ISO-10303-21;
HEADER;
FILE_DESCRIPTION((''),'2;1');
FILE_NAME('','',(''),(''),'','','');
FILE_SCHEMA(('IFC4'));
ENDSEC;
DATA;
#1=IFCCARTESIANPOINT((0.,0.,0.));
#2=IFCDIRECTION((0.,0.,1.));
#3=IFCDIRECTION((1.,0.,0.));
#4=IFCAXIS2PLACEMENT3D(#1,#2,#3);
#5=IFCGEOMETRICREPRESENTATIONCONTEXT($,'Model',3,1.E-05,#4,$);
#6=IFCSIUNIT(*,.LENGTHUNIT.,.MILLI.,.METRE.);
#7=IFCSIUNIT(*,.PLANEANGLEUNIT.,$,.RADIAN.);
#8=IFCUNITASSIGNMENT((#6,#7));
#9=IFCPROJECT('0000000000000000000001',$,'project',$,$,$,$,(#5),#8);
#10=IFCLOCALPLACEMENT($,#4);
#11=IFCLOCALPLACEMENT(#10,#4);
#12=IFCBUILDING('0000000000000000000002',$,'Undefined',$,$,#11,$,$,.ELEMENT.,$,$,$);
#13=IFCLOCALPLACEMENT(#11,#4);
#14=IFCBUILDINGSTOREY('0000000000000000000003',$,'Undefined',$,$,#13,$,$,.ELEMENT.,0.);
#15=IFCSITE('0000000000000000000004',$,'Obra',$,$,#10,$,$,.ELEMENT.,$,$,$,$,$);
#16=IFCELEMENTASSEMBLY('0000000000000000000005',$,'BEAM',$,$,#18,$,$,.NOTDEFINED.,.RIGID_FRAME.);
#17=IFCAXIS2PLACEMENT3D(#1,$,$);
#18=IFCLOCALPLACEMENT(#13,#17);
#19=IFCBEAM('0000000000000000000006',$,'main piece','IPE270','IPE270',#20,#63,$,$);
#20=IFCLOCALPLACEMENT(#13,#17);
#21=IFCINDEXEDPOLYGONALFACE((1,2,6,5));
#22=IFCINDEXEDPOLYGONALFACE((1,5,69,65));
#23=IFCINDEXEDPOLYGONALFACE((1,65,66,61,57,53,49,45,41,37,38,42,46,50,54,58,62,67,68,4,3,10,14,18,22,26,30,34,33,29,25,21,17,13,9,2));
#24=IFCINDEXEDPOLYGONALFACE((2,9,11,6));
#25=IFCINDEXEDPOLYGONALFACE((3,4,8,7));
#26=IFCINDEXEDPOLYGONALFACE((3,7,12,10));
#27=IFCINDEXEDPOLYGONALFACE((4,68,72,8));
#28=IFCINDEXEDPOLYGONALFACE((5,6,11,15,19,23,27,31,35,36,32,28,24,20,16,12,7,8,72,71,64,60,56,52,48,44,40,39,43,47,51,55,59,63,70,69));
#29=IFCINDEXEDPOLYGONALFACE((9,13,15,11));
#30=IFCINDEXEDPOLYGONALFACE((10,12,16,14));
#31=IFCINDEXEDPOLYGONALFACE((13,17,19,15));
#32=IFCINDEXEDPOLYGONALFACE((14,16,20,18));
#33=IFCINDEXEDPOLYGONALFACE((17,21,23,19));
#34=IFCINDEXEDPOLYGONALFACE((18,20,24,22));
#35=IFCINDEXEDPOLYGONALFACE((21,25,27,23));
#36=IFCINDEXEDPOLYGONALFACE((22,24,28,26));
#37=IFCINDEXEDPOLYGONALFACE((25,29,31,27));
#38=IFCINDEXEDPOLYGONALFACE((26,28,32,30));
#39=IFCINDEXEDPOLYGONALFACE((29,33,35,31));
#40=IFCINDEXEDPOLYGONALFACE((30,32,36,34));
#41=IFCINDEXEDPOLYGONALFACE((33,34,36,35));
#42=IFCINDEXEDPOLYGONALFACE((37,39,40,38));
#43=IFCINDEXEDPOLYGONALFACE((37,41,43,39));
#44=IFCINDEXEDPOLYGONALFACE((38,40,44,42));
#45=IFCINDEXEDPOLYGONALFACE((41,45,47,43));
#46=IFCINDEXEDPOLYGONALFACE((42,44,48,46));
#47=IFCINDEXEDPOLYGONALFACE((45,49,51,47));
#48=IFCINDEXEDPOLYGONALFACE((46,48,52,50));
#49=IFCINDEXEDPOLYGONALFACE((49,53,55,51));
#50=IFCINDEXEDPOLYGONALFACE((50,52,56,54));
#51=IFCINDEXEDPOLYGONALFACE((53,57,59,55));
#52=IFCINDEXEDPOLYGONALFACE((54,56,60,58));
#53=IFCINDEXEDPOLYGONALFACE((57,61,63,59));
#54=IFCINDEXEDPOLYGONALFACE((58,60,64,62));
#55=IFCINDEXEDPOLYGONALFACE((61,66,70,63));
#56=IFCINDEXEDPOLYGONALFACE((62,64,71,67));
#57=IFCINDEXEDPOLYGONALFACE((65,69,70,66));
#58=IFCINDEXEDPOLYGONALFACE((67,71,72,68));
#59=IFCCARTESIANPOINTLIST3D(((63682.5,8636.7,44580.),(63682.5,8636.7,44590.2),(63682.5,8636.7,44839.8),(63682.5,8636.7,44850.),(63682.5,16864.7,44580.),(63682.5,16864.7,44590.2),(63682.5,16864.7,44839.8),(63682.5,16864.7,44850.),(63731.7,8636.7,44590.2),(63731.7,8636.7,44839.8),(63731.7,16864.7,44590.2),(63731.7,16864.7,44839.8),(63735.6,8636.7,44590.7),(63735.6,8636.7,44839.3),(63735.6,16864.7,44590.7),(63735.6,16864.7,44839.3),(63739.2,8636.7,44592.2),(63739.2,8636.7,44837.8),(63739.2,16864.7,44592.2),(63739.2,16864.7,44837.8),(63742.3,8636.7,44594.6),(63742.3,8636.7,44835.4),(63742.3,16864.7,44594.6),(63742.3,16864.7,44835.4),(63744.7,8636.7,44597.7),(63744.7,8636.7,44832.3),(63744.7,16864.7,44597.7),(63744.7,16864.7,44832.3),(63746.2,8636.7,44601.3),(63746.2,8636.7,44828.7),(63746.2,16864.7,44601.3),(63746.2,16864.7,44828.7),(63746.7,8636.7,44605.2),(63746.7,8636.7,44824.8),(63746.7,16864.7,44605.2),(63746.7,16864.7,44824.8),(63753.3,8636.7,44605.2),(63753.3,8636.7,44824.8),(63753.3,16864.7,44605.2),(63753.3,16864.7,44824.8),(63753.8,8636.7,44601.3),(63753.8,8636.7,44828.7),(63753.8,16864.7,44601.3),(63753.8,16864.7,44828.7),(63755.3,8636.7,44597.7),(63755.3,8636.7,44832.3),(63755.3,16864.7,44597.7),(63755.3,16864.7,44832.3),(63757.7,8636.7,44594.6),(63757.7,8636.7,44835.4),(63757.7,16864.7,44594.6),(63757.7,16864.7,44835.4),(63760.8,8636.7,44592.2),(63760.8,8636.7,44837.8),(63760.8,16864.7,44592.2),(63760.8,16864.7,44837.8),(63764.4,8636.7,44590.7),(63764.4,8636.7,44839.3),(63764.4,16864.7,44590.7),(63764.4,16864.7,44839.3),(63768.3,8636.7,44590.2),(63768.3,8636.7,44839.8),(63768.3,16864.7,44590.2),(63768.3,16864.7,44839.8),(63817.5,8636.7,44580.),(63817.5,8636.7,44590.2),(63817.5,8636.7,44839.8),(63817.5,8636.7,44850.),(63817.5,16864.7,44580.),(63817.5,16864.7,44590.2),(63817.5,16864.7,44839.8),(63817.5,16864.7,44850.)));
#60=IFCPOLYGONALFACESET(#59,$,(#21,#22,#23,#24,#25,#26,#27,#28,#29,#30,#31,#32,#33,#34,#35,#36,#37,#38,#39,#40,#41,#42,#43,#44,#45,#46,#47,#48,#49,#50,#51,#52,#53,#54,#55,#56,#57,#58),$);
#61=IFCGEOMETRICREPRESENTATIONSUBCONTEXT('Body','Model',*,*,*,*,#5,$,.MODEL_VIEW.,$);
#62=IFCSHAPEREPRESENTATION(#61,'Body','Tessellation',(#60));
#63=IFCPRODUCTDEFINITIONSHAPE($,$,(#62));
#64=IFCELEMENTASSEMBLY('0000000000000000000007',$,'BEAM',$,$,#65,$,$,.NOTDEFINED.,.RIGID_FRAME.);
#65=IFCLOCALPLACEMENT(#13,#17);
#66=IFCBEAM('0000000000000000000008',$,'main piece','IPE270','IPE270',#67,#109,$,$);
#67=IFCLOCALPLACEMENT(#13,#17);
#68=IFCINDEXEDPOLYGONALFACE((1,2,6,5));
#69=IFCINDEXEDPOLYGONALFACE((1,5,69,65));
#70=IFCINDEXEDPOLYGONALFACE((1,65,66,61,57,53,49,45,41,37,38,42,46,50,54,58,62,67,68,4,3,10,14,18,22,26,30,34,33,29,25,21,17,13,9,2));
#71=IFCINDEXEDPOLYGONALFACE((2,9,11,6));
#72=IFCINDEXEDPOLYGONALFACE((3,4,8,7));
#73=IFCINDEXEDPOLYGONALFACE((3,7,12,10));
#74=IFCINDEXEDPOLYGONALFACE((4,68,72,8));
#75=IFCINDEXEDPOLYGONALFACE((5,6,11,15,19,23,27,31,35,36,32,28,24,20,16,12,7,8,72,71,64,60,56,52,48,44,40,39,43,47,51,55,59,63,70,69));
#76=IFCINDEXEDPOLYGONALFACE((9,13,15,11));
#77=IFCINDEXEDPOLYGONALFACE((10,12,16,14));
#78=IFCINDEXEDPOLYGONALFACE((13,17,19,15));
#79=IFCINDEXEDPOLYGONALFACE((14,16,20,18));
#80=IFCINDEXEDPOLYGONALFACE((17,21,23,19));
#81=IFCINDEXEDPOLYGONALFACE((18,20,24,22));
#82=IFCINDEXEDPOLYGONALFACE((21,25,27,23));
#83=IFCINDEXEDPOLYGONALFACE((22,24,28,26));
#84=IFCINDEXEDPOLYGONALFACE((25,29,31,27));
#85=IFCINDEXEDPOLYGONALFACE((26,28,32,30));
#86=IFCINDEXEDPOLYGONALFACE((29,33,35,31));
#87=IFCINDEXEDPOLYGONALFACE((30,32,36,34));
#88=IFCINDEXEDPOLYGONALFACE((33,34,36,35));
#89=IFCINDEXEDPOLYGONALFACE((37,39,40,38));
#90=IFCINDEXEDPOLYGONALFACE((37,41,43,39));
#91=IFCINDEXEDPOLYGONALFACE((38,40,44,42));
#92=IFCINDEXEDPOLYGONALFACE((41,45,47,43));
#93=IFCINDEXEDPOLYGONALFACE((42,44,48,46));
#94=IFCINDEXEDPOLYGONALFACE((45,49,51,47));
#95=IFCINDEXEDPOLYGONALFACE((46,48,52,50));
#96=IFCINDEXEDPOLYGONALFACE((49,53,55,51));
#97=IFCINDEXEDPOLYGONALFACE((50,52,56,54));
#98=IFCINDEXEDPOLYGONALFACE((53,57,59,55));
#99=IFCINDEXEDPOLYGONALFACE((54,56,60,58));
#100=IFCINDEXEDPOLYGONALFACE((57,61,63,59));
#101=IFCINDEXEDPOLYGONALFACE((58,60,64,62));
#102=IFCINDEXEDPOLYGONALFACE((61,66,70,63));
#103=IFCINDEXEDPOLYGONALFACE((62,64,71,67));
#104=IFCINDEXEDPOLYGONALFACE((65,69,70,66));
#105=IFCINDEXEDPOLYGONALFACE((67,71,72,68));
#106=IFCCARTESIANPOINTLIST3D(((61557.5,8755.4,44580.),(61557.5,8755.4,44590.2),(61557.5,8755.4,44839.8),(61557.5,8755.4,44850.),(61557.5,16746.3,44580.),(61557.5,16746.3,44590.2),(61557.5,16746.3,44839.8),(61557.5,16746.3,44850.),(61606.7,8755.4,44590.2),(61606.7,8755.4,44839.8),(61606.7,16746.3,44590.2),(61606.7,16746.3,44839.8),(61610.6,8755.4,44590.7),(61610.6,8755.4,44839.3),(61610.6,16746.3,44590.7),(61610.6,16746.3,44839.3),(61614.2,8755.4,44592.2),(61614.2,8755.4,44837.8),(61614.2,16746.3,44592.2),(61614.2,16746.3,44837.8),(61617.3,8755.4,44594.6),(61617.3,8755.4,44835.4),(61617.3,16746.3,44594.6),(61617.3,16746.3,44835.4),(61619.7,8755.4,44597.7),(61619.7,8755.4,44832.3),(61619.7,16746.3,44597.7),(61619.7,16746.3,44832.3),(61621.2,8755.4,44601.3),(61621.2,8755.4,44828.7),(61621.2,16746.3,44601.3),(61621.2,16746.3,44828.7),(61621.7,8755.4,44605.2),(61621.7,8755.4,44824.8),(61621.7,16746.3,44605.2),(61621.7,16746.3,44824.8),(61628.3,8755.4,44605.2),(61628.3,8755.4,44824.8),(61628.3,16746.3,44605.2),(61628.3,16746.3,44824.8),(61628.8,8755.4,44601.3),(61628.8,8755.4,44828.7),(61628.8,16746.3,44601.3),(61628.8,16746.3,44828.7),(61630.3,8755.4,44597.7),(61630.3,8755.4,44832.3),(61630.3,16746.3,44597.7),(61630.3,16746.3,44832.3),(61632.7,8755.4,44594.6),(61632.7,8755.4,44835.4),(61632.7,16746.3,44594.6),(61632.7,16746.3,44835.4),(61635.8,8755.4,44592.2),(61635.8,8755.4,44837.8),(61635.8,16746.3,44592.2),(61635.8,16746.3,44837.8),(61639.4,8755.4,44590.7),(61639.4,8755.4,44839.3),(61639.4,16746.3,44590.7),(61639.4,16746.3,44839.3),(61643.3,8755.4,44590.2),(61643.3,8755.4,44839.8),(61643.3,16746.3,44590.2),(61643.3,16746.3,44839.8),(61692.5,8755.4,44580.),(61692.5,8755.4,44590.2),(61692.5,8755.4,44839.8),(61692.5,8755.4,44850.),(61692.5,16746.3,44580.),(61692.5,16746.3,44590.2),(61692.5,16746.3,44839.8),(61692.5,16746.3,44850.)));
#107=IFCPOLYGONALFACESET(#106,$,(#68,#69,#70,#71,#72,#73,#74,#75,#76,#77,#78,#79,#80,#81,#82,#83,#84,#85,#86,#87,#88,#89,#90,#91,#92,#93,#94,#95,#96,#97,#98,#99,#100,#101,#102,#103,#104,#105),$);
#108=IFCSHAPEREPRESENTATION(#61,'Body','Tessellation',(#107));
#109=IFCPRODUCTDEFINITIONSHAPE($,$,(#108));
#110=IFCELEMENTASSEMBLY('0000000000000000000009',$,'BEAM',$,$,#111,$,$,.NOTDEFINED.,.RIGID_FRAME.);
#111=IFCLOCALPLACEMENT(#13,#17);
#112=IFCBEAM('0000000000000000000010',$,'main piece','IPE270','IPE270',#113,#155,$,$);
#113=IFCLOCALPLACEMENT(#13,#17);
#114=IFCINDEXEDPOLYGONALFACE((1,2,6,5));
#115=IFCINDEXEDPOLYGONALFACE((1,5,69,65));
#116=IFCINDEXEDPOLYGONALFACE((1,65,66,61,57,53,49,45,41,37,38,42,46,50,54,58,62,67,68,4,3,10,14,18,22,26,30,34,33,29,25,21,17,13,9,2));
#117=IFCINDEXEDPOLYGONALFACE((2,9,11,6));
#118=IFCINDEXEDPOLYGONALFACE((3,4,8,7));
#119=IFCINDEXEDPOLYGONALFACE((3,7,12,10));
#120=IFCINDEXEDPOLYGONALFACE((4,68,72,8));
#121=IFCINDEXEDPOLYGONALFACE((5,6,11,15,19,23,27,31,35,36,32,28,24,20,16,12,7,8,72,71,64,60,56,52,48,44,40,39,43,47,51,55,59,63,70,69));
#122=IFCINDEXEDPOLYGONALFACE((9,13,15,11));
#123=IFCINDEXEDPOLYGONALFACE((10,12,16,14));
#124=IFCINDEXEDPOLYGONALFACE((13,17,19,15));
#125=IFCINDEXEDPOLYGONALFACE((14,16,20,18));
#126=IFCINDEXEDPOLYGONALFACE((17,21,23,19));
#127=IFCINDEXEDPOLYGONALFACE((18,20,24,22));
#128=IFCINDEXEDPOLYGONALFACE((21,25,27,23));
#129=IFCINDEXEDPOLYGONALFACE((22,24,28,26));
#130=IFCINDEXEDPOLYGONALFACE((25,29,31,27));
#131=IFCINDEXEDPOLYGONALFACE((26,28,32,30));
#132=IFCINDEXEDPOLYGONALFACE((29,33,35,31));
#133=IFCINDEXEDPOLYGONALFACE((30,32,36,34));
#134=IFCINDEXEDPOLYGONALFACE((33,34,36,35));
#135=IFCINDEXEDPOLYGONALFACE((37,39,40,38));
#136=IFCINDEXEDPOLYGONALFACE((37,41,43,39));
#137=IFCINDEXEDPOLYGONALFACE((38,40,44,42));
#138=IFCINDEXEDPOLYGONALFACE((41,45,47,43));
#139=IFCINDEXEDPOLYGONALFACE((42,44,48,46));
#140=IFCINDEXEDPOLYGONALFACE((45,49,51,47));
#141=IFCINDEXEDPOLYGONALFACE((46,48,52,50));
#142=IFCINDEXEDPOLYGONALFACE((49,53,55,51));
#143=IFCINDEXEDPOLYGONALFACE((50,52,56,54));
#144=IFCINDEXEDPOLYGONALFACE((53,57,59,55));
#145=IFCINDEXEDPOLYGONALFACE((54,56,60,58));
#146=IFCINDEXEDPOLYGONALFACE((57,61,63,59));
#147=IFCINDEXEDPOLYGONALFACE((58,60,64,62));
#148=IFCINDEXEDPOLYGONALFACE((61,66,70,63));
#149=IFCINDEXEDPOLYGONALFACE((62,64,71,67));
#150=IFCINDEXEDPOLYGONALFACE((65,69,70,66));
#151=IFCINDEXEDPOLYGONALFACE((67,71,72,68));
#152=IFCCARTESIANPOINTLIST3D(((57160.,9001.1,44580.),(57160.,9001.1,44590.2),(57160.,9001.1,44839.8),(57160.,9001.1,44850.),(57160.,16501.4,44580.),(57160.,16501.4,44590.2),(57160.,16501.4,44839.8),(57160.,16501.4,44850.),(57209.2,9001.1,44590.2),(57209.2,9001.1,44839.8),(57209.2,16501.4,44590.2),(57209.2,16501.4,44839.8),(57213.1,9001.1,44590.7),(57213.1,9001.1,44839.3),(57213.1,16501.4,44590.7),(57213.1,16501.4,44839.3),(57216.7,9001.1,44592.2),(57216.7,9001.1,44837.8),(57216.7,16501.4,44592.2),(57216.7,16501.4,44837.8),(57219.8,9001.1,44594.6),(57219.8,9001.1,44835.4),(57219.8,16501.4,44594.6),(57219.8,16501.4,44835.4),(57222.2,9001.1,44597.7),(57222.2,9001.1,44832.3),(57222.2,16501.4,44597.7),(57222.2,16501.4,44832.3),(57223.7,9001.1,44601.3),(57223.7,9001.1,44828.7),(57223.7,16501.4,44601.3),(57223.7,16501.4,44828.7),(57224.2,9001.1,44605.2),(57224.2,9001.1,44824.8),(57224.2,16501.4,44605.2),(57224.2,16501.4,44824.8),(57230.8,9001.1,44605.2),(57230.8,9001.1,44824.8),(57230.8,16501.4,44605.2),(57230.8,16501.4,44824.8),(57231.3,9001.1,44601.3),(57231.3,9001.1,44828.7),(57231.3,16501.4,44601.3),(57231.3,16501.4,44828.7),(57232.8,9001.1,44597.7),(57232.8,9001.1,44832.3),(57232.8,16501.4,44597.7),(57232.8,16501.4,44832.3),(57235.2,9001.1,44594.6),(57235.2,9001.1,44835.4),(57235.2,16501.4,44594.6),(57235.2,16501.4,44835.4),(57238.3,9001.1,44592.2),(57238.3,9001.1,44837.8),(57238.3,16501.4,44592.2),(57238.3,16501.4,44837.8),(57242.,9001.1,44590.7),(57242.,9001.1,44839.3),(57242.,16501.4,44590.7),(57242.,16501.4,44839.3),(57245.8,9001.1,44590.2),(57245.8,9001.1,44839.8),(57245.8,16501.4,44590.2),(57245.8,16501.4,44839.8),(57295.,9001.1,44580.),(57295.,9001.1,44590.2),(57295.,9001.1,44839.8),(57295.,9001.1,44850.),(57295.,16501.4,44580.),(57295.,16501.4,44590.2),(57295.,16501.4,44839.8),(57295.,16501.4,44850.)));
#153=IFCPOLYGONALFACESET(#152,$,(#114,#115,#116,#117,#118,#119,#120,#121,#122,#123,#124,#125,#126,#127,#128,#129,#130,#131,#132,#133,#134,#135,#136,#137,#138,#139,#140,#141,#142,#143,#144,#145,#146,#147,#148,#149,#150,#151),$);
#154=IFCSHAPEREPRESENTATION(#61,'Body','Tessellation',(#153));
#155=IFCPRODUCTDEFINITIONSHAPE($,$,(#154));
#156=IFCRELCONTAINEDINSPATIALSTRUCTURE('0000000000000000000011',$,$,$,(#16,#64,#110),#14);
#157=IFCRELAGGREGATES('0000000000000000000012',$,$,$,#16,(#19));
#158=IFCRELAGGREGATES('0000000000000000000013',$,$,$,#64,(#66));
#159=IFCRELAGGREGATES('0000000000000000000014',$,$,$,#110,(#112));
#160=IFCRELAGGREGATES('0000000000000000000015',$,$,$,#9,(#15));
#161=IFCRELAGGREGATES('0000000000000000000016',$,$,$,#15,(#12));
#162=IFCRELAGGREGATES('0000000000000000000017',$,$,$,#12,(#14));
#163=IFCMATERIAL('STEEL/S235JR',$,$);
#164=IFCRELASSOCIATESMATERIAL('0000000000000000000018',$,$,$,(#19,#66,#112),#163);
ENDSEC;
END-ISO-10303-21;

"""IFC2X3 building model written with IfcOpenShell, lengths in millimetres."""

from ifc_helpers import new_model, si_unit, frame, origin_with_axes, origin_2d_with_axis, place, context, subcontext, project, spatial, i_section, extrude, material, element, aggregate, save


model = new_model("IFC2X3")

# Units and contexts
model_context = context("Model", 3, precision=1e-05, world=origin_with_axes())
body_context = subcontext(model_context, "Body", "Model", "MODEL_VIEW")
ifc_project = project(units=[si_unit("LENGTHUNIT", "METRE", prefix="MILLI"), si_unit("PLANEANGLEUNIT", "RADIAN")], contexts=[model_context])

# Site, building, storey
site_placement = place(None, origin_with_axes())
site = spatial("IfcSite", under=ifc_project, at=site_placement, Name="Obra", CompositionType="ELEMENT")
building_placement = place(site_placement, origin_with_axes())
building = spatial("IfcBuilding", under=site, at=building_placement, Name="Undefined", CompositionType="ELEMENT")
storey_placement = place(building_placement, origin_with_axes())
storey = spatial("IfcBuildingStorey", under=building, at=storey_placement, Name="Undefined", CompositionType="ELEMENT", Elevation=0.0)

# Shared definitions
ifc_material_1 = material(Name="STEEL/S235JR")

# Element assemblies, beams
assembly_1_placement = place(storey_placement, origin_with_axes())
assembly_1 = element("IfcElementAssembly", 1, at=assembly_1_placement, inside=storey, Name="BEAM", AssemblyPlace="NOTDEFINED", PredefinedType="RIGID_FRAME")
beam_1_placement = place(assembly_1_placement, frame((63750.0, 8636.7, 44715.0), z_axis=(0.0, 0.0, 1.0), x_axis=(0.0, 1.0, 0.0)))
beam_1 = element("IfcBeam", 2, at=beam_1_placement, material=ifc_material_1, Name="main piece", Description="IPE270", ObjectType="IPE270", context=body_context, shape_type="SweptSolid", body=[
    extrude(i_section(OverallWidth=135.0, OverallDepth=270.0, WebThickness=6.6, FlangeThickness=10.2, FilletRadius=15.0, at=origin_2d_with_axis()), frame((8228.0, 0.0, 0.0), z_axis=(-1.0, 0.0, 0.0), x_axis=(0.0, -1.0, 0.0)), (0.0, 0.0, 1.0), 8228.0),
])
aggregate(assembly_1, [beam_1])
assembly_2_placement = place(storey_placement, origin_with_axes())
assembly_2 = element("IfcElementAssembly", 3, at=assembly_2_placement, inside=storey, Name="BEAM", AssemblyPlace="NOTDEFINED", PredefinedType="RIGID_FRAME")
beam_2_placement = place(assembly_2_placement, frame((61625.0, 16746.3, 44715.0), z_axis=(0.0, 0.0, 1.0), x_axis=(0.0, -1.0, 0.0)))
beam_2 = element("IfcBeam", 4, at=beam_2_placement, material=ifc_material_1, Name="main piece", Description="IPE270", ObjectType="IPE270", context=body_context, shape_type="SweptSolid", body=[
    extrude(i_section(OverallWidth=135.0, OverallDepth=270.0, WebThickness=6.6, FlangeThickness=10.2, FilletRadius=15.0, at=origin_2d_with_axis()), frame((7990.9, 0.0, 0.0), z_axis=(-1.0, 0.0, 0.0), x_axis=(0.0, -1.0, 0.0)), (0.0, 0.0, 1.0), 7990.9),
])
aggregate(assembly_2, [beam_2])
assembly_3_placement = place(storey_placement, origin_with_axes())
assembly_3 = element("IfcElementAssembly", 5, at=assembly_3_placement, inside=storey, Name="BEAM", AssemblyPlace="NOTDEFINED", PredefinedType="RIGID_FRAME")
beam_3_placement = place(assembly_3_placement, frame((57227.5, 9001.1, 44715.0), z_axis=(0.0, 0.0, 1.0), x_axis=(0.0, 1.0, 0.0)))
beam_3 = element("IfcBeam", 6, at=beam_3_placement, material=ifc_material_1, Name="main piece", Description="IPE270", ObjectType="IPE270", context=body_context, shape_type="SweptSolid", body=[
    extrude(i_section(OverallWidth=135.0, OverallDepth=270.0, WebThickness=6.6, FlangeThickness=10.2, FilletRadius=15.0, at=origin_2d_with_axis()), frame((7500.3, 0.0, 0.0), z_axis=(-1.0, 0.0, 0.0), x_axis=(0.0, -1.0, 0.0)), (0.0, 0.0, 1.0), 7500.3),
])
aggregate(assembly_3, [beam_3])

save(model, "model.ifc")
